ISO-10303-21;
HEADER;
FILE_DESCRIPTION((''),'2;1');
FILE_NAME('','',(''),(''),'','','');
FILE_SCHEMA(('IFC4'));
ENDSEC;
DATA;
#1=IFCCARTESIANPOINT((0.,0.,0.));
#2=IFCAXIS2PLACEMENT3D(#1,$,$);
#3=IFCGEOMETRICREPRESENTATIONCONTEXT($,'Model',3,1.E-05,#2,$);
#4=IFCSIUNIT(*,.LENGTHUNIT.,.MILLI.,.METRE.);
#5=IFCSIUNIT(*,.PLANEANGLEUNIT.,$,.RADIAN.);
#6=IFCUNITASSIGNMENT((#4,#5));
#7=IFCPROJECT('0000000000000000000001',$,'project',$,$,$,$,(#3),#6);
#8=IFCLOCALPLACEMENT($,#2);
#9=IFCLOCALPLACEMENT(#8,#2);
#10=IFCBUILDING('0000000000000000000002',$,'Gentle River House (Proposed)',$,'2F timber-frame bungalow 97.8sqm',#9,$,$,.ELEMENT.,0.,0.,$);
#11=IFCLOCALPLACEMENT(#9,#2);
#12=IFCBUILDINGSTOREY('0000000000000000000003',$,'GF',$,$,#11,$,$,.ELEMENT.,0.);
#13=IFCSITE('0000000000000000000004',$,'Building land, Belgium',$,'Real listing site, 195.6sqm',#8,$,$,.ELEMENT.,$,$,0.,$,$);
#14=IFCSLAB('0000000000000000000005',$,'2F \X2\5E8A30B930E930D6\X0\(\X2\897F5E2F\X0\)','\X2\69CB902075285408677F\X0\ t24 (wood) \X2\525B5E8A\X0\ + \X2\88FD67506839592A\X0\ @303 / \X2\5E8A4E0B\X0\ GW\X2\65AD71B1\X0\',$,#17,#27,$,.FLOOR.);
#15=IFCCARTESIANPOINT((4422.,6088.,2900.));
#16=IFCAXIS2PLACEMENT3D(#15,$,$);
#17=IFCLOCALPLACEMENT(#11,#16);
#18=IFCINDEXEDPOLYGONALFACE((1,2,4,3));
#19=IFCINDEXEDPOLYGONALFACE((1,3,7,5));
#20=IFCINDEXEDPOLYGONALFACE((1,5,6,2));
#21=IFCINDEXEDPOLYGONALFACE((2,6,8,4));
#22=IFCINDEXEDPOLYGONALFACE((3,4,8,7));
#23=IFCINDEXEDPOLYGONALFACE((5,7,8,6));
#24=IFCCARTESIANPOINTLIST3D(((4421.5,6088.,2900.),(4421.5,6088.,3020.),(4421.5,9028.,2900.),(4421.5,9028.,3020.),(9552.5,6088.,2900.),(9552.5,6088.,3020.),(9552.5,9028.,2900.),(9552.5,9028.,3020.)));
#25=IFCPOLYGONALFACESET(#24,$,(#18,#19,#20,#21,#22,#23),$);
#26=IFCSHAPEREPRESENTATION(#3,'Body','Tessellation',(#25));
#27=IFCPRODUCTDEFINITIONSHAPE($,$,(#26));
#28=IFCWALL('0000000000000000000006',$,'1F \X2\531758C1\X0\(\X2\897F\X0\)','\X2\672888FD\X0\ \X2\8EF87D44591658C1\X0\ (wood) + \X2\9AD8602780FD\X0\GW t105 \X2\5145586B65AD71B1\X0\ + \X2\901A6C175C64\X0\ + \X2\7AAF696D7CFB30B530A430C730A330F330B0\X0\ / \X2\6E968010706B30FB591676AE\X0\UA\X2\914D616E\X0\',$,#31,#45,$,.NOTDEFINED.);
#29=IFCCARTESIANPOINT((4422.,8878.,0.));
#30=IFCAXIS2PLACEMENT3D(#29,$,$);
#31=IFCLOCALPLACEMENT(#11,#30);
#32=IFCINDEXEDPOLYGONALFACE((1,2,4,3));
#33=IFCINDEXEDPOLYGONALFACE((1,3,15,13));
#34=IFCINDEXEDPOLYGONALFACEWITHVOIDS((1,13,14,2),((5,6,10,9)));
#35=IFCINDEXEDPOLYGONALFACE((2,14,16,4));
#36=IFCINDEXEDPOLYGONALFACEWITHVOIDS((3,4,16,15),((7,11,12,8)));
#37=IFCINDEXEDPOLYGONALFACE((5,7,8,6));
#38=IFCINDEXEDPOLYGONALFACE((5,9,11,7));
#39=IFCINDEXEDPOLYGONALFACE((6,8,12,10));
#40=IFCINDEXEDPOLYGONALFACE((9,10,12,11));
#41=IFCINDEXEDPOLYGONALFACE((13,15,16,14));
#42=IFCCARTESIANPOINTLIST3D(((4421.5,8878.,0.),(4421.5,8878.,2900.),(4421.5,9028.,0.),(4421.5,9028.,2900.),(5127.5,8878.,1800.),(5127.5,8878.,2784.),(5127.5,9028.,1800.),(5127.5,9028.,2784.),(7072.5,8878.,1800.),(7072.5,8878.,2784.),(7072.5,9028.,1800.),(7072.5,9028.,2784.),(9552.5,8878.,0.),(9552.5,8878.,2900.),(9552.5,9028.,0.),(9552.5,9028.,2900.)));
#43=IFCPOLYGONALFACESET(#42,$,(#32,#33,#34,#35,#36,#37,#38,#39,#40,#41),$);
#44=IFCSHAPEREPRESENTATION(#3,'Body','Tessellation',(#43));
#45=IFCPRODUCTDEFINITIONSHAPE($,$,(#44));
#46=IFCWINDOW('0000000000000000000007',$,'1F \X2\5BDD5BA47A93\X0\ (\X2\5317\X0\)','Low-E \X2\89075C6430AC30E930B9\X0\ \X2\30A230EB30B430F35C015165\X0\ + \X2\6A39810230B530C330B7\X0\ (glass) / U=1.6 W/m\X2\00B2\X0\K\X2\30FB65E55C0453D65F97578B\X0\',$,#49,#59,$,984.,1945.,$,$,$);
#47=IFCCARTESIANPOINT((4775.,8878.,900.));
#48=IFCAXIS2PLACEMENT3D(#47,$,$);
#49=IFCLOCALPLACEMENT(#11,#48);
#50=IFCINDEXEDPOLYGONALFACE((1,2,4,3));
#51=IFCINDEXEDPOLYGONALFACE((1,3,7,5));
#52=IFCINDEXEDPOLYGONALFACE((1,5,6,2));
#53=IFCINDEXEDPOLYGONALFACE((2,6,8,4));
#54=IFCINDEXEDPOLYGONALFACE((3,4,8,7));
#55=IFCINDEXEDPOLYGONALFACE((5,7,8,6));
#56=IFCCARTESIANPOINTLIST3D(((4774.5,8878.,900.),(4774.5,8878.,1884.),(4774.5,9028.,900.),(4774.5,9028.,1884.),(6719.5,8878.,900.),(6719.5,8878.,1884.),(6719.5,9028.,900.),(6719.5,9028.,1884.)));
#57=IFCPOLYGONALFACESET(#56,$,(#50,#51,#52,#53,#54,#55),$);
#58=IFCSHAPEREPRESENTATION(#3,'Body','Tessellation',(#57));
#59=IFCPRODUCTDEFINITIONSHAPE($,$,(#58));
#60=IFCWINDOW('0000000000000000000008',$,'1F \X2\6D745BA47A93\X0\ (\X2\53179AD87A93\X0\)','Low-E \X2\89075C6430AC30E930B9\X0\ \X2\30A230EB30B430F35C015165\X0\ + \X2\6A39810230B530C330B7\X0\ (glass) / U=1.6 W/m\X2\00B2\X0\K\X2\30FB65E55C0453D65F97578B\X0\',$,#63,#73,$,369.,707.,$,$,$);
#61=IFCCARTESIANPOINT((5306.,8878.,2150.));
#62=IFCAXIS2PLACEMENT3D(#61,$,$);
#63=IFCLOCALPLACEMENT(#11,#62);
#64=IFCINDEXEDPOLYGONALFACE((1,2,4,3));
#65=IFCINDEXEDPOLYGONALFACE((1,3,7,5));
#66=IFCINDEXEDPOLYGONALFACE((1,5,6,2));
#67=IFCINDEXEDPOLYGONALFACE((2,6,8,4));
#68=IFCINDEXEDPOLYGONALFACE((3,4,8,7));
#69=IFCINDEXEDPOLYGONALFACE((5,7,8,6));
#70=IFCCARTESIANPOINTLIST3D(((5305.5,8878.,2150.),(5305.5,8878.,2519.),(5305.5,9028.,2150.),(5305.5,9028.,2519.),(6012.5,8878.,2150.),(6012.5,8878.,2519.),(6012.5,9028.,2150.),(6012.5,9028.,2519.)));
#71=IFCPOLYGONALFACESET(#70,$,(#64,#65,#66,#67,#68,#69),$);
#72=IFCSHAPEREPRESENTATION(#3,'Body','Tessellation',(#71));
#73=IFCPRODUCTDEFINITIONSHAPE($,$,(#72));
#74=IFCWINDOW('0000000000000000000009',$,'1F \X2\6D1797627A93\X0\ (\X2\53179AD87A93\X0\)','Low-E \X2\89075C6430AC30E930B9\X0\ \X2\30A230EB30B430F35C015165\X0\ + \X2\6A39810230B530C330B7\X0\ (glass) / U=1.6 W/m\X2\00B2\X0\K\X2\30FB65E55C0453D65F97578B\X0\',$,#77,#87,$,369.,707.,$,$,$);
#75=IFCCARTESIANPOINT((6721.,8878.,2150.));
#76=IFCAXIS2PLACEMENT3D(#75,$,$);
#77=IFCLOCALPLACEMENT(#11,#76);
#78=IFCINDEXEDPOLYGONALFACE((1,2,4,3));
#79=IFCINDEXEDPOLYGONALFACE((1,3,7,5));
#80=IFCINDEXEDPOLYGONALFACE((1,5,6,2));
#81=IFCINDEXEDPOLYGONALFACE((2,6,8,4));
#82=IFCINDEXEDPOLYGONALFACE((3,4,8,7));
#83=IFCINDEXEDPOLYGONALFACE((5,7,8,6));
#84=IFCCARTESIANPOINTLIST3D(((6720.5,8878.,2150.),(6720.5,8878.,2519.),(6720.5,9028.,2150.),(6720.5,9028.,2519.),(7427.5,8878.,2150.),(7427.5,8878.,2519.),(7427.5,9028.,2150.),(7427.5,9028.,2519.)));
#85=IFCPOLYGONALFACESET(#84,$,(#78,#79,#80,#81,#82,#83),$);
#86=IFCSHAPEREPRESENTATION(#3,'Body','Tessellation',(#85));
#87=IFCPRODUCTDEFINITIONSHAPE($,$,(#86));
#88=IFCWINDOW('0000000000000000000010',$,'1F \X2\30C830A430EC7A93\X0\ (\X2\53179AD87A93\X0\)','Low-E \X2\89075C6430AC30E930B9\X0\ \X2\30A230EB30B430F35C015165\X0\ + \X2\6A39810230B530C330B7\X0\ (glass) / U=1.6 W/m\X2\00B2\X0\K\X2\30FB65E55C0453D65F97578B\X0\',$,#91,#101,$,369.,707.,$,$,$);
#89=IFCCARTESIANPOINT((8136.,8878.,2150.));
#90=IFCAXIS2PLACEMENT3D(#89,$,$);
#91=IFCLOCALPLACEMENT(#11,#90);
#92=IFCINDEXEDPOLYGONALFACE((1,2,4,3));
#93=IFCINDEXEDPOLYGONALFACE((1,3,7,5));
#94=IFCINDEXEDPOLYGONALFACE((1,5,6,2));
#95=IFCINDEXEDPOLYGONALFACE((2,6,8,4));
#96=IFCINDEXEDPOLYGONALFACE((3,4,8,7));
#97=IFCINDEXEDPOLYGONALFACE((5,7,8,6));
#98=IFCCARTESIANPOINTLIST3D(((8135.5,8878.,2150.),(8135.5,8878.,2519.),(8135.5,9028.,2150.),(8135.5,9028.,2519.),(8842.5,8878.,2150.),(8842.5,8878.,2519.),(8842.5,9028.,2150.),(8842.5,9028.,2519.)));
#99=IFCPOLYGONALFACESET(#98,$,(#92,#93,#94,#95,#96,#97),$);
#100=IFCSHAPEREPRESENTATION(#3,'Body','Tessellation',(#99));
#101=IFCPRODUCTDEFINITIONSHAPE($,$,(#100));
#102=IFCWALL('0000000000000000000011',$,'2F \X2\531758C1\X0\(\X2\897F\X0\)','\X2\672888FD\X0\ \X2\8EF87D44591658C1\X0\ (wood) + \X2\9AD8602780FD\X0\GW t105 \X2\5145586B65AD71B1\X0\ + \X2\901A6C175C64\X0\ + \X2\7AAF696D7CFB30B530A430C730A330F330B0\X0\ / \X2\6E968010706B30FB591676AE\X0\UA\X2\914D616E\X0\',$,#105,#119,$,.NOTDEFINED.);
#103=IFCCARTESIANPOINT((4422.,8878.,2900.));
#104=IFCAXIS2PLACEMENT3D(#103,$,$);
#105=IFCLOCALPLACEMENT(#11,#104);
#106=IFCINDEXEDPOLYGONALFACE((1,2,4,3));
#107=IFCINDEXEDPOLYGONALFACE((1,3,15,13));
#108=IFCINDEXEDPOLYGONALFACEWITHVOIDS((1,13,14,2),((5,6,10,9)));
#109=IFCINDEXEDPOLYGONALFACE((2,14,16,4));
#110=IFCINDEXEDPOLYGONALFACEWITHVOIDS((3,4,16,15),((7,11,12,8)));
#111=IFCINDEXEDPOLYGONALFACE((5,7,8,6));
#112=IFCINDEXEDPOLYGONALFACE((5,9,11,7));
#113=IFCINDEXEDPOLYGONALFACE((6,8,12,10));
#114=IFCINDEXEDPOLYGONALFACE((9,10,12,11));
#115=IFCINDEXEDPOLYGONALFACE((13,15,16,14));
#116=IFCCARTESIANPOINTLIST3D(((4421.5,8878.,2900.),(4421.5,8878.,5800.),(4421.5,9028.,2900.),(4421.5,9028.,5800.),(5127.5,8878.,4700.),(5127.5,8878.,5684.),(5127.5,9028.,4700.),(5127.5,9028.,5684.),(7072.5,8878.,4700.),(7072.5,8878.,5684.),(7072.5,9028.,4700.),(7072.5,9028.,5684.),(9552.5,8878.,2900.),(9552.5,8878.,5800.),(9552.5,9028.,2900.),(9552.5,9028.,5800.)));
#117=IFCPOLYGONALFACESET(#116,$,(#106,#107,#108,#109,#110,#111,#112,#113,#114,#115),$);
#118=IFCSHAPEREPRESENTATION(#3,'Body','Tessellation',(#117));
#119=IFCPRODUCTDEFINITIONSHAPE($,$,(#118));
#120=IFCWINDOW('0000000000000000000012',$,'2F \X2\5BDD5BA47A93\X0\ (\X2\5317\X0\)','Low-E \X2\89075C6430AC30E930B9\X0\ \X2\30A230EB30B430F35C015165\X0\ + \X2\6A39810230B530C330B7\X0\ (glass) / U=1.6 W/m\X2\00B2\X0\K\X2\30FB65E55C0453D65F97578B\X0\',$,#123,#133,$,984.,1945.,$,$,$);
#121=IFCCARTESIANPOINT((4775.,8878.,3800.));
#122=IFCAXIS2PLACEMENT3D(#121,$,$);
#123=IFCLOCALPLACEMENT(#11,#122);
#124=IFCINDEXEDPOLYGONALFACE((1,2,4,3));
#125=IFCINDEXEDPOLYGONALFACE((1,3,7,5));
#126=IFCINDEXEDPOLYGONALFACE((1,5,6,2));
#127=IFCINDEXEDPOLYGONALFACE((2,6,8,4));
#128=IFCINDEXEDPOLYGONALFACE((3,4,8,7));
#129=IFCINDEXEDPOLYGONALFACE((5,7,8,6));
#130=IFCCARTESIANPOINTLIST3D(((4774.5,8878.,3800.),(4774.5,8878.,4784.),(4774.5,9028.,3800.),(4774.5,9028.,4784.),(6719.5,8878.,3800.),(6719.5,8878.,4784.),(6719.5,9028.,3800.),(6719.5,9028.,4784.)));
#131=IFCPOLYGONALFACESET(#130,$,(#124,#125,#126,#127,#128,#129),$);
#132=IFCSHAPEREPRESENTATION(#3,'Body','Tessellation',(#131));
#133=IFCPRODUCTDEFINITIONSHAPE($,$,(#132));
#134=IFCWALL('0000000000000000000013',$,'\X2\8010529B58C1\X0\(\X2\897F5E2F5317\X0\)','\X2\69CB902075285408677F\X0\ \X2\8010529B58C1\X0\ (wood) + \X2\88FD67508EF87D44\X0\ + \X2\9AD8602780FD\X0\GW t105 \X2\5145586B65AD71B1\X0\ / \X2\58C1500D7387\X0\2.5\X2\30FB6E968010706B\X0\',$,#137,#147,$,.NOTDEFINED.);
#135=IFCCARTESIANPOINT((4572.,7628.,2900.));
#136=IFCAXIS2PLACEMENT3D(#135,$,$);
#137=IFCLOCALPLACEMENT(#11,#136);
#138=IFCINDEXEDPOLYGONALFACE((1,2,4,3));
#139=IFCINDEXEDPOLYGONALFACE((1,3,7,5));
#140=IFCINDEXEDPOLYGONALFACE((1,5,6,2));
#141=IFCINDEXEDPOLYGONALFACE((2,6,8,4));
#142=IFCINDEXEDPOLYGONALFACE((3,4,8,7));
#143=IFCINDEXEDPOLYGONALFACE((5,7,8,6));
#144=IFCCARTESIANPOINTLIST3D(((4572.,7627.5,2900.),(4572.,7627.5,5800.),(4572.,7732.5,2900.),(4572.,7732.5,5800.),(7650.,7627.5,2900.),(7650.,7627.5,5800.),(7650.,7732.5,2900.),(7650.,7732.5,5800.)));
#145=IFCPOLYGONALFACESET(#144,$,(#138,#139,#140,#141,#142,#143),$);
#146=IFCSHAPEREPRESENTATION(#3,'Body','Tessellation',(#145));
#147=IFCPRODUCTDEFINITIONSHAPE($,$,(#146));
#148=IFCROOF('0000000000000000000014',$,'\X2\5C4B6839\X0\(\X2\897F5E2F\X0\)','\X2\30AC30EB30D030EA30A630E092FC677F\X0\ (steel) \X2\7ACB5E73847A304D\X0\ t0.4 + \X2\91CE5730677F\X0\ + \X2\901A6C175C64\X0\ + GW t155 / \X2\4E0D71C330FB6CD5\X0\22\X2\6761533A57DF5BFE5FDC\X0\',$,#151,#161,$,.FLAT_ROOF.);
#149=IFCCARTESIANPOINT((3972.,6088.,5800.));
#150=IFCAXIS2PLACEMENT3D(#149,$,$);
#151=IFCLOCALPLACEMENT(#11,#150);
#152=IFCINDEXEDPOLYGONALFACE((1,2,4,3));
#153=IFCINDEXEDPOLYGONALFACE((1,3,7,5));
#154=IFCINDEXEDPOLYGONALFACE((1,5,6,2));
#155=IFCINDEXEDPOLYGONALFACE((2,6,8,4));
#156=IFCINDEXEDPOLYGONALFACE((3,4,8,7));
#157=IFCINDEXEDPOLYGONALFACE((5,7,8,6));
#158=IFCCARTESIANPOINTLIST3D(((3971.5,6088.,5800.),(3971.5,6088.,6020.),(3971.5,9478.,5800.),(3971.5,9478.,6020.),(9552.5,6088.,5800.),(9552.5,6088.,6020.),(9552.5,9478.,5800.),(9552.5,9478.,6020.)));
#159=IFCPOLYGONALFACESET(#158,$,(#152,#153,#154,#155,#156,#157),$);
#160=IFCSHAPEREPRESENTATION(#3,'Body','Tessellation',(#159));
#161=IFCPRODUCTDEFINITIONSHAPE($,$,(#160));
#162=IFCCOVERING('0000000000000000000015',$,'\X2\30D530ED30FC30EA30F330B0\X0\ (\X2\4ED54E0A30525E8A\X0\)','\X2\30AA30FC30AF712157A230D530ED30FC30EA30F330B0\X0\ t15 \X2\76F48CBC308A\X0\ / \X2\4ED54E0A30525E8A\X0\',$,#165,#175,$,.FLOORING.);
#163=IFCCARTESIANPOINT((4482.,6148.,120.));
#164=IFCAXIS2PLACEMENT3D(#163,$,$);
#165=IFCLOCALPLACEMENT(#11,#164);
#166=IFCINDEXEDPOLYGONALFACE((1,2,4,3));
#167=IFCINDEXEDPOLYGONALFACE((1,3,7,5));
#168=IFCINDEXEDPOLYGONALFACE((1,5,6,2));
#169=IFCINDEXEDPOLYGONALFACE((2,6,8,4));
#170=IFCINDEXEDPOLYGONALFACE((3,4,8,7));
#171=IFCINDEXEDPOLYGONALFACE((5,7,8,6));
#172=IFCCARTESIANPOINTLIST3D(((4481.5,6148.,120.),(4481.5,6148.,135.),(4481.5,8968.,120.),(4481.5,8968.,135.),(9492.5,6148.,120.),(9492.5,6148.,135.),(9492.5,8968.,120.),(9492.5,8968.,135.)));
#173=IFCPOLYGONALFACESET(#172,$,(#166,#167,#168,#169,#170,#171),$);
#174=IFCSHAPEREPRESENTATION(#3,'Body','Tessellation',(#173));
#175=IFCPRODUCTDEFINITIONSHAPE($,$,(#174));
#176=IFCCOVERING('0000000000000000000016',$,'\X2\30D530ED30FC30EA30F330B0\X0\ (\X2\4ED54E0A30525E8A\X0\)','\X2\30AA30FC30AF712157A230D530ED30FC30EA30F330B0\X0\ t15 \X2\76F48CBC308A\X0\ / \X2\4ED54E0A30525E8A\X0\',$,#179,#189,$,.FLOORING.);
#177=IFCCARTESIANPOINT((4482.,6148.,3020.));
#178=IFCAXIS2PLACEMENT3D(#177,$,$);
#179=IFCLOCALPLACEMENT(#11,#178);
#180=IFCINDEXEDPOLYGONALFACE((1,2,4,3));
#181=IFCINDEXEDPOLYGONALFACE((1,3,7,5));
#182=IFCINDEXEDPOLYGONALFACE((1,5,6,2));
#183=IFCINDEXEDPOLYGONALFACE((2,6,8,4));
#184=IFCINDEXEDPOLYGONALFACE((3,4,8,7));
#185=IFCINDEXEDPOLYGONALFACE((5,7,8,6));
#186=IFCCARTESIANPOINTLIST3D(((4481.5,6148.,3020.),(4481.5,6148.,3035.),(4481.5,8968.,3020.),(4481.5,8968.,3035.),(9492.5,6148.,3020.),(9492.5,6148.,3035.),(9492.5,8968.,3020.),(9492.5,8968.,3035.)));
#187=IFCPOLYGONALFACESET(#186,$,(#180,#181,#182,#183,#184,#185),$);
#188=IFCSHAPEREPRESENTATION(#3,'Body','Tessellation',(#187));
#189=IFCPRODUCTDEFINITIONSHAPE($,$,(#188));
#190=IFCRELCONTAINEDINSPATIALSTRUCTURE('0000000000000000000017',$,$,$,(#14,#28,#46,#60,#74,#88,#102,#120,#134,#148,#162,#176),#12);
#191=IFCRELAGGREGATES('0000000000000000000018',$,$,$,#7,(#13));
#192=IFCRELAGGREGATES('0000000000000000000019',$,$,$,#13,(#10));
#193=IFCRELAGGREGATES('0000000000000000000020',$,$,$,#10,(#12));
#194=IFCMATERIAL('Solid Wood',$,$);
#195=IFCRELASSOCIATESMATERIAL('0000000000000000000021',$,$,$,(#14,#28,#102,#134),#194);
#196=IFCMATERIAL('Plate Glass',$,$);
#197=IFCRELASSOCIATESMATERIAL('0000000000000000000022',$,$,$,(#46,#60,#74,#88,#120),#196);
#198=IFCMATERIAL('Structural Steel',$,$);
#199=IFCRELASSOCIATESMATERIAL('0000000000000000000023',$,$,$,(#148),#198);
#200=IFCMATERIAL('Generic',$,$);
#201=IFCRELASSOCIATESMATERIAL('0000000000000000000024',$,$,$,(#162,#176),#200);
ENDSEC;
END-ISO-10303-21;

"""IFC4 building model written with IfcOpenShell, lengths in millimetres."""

from ifc_helpers import new_model, si_unit, frame, frame_2d, origin, place, context, project, spatial, rectangle, extrude, material, element, fill, save


model = new_model("IFC4")

# Units and contexts
model_context = context("Model", 3, precision=1e-05, world=origin())
ifc_project = project(units=[si_unit("LENGTHUNIT", "METRE", prefix="MILLI"), si_unit("PLANEANGLEUNIT", "RADIAN")], contexts=[model_context])

# Site, building, storey
site_placement = place(None, origin())
site = spatial("IfcSite", under=ifc_project, at=site_placement, Name="Building land, Belgium", ObjectType="Real listing site, 195.6sqm", CompositionType="ELEMENT", RefElevation=0.0)
building_placement = place(site_placement, origin())
building = spatial("IfcBuilding", under=site, at=building_placement, Name="Gentle River House (Proposed)", ObjectType="2F timber-frame bungalow 97.8sqm", CompositionType="ELEMENT", ElevationOfRefHeight=0.0, ElevationOfTerrain=0.0)
storey_placement = place(building_placement, origin())
storey = spatial("IfcBuildingStorey", under=building, at=storey_placement, Name="GF", CompositionType="ELEMENT", Elevation=0.0)

# Slab
ifc_material_1 = material(Name="Solid Wood")
slab_1_placement = place(storey_placement, frame((4422.0, 6088.0, 2900.0)))
element("IfcSlab", 1, at=slab_1_placement, inside=storey, material=ifc_material_1, Name="2F 床スラブ(西帯)", Description="構造用合板 t24 (wood) 剛床 + 製材根太 @303 / 床下 GW断熱", PredefinedType="FLOOR", context=model_context, shape_type="SweptSolid", body=[
    extrude(rectangle(XDim=5131.0, YDim=2940.0, at=frame_2d((2565.0, 1470.0))), frame((4422.0, 6088.0, 2900.0)), (0.0, 0.0, 1.0), 120.0),
])

# Wall, openings, windows
wall_1_placement = place(storey_placement, frame((4422.0, 8878.0, 0.0)))
wall_1 = element("IfcWall", 2, at=wall_1_placement, inside=storey, material=ifc_material_1, Name="1F 北壁(西)", Description="木製 軸組外壁 (wood) + 高性能GW t105 充填断熱 + 通気層 + 窯業系サイディング / 準耐火・外皮UA配慮", PredefinedType="NOTDEFINED", context=model_context, shape_type="SweptSolid", body=[
    extrude(rectangle(XDim=5131.0, YDim=150.0, at=frame_2d((2565.0, 75.0))), frame((4422.0, 8878.0, 0.0)), (0.0, 0.0, 1.0), 2900.0),
])
opening_1_placement = place(storey_placement, frame((4775.0, 8878.0, 900.0)))
opening_1 = element("IfcOpeningElement", 3, at=opening_1_placement, cuts=wall_1, PredefinedType="NOTDEFINED", context=model_context, shape_type="SweptSolid", body=[
    extrude(rectangle(XDim=1945.0, YDim=150.0, at=frame_2d((972.0, 75.0))), frame((4775.0, 8878.0, 900.0)), (0.0, 0.0, 1.0), 984.0),
])
opening_2_placement = place(storey_placement, frame((5306.0, 8878.0, 2150.0)))
opening_2 = element("IfcOpeningElement", 4, at=opening_2_placement, cuts=wall_1, PredefinedType="NOTDEFINED", context=model_context, shape_type="SweptSolid", body=[
    extrude(rectangle(XDim=707.0, YDim=150.0, at=frame_2d((353.0, 75.0))), frame((5306.0, 8878.0, 2150.0)), (0.0, 0.0, 1.0), 369.0),
])
opening_3_placement = place(storey_placement, frame((6721.0, 8878.0, 2150.0)))
opening_3 = element("IfcOpeningElement", 5, at=opening_3_placement, cuts=wall_1, PredefinedType="NOTDEFINED", context=model_context, shape_type="SweptSolid", body=[
    extrude(rectangle(XDim=707.0, YDim=150.0, at=frame_2d((353.0, 75.0))), frame((6721.0, 8878.0, 2150.0)), (0.0, 0.0, 1.0), 369.0),
])
opening_4_placement = place(storey_placement, frame((8136.0, 8878.0, 2150.0)))
opening_4 = element("IfcOpeningElement", 6, at=opening_4_placement, cuts=wall_1, PredefinedType="NOTDEFINED", context=model_context, shape_type="SweptSolid", body=[
    extrude(rectangle(XDim=707.0, YDim=150.0, at=frame_2d((353.0, 75.0))), frame((8136.0, 8878.0, 2150.0)), (0.0, 0.0, 1.0), 369.0),
])
ifc_material_2 = material(Name="Plate Glass")
window_1_placement = place(storey_placement, frame((4775.0, 8878.0, 900.0)))
window_1 = element("IfcWindow", 7, at=window_1_placement, inside=storey, material=ifc_material_2, Name="1F 寝室窓 (北)", Description="Low-E 複層ガラス アルゴン封入 + 樹脂サッシ (glass) / U=1.6 W/m²K・日射取得型", OverallHeight=984.0, OverallWidth=1945.0, context=model_context, shape_type="SweptSolid", body=[
    extrude(rectangle(XDim=1945.0, YDim=150.0, at=frame_2d((972.0, 75.0))), frame((4775.0, 8878.0, 900.0)), (0.0, 0.0, 1.0), 984.0),
])
fill(opening_1, window_1)
window_2_placement = place(storey_placement, frame((5306.0, 8878.0, 2150.0)))
window_2 = element("IfcWindow", 8, at=window_2_placement, inside=storey, material=ifc_material_2, Name="1F 浴室窓 (北高窓)", Description="Low-E 複層ガラス アルゴン封入 + 樹脂サッシ (glass) / U=1.6 W/m²K・日射取得型", OverallHeight=369.0, OverallWidth=707.0, context=model_context, shape_type="SweptSolid", body=[
    extrude(rectangle(XDim=707.0, YDim=150.0, at=frame_2d((353.0, 75.0))), frame((5306.0, 8878.0, 2150.0)), (0.0, 0.0, 1.0), 369.0),
])
fill(opening_2, window_2)
window_3_placement = place(storey_placement, frame((6721.0, 8878.0, 2150.0)))
window_3 = element("IfcWindow", 9, at=window_3_placement, inside=storey, material=ifc_material_2, Name="1F 洗面窓 (北高窓)", Description="Low-E 複層ガラス アルゴン封入 + 樹脂サッシ (glass) / U=1.6 W/m²K・日射取得型", OverallHeight=369.0, OverallWidth=707.0, context=model_context, shape_type="SweptSolid", body=[
    extrude(rectangle(XDim=707.0, YDim=150.0, at=frame_2d((353.0, 75.0))), frame((6721.0, 8878.0, 2150.0)), (0.0, 0.0, 1.0), 369.0),
])
fill(opening_3, window_3)
window_4_placement = place(storey_placement, frame((8136.0, 8878.0, 2150.0)))
window_4 = element("IfcWindow", 10, at=window_4_placement, inside=storey, material=ifc_material_2, Name="1F トイレ窓 (北高窓)", Description="Low-E 複層ガラス アルゴン封入 + 樹脂サッシ (glass) / U=1.6 W/m²K・日射取得型", OverallHeight=369.0, OverallWidth=707.0, context=model_context, shape_type="SweptSolid", body=[
    extrude(rectangle(XDim=707.0, YDim=150.0, at=frame_2d((353.0, 75.0))), frame((8136.0, 8878.0, 2150.0)), (0.0, 0.0, 1.0), 369.0),
])
fill(opening_4, window_4)

# Wall, opening, window
wall_2_placement = place(storey_placement, frame((4422.0, 8878.0, 2900.0)))
wall_2 = element("IfcWall", 11, at=wall_2_placement, inside=storey, material=ifc_material_1, Name="2F 北壁(西)", Description="木製 軸組外壁 (wood) + 高性能GW t105 充填断熱 + 通気層 + 窯業系サイディング / 準耐火・外皮UA配慮", PredefinedType="NOTDEFINED", context=model_context, shape_type="SweptSolid", body=[
    extrude(rectangle(XDim=5131.0, YDim=150.0, at=frame_2d((2565.0, 75.0))), frame((4422.0, 8878.0, 2900.0)), (0.0, 0.0, 1.0), 2900.0),
])
opening_5_placement = place(storey_placement, frame((4775.0, 8878.0, 3800.0)))
opening_5 = element("IfcOpeningElement", 12, at=opening_5_placement, cuts=wall_2, PredefinedType="NOTDEFINED", context=model_context, shape_type="SweptSolid", body=[
    extrude(rectangle(XDim=1945.0, YDim=150.0, at=frame_2d((972.0, 75.0))), frame((4775.0, 8878.0, 3800.0)), (0.0, 0.0, 1.0), 984.0),
])
window_5_placement = place(storey_placement, frame((4775.0, 8878.0, 3800.0)))
window_5 = element("IfcWindow", 13, at=window_5_placement, inside=storey, material=ifc_material_2, Name="2F 寝室窓 (北)", Description="Low-E 複層ガラス アルゴン封入 + 樹脂サッシ (glass) / U=1.6 W/m²K・日射取得型", OverallHeight=984.0, OverallWidth=1945.0, context=model_context, shape_type="SweptSolid", body=[
    extrude(rectangle(XDim=1945.0, YDim=150.0, at=frame_2d((972.0, 75.0))), frame((4775.0, 8878.0, 3800.0)), (0.0, 0.0, 1.0), 984.0),
])
fill(opening_5, window_5)

# Wall
wall_3_placement = place(storey_placement, frame((4572.0, 7628.0, 2900.0)))
element("IfcWall", 14, at=wall_3_placement, inside=storey, material=ifc_material_1, Name="耐力壁(西帯北)", Description="構造用合板 耐力壁 (wood) + 製材軸組 + 高性能GW t105 充填断熱 / 壁倍率2.5・準耐火", PredefinedType="NOTDEFINED", context=model_context, shape_type="SweptSolid", body=[
    extrude(rectangle(XDim=3078.0, YDim=105.0, at=frame_2d((1539.0, 52.0))), frame((4572.0, 7628.0, 2900.0)), (0.0, 0.0, 1.0), 2900.0),
])

# Roof
ifc_material_3 = material(Name="Structural Steel")
for number, where, name in (
    (15, (3972.0, 6088.0, 5800.0), "屋根(西帯)"),
):
    element("IfcRoof", number, at=place(storey_placement, frame(where)), inside=storey, material=ifc_material_3, Name=name, Description="ガルバリウム鋼板 (steel) 立平葺き t0.4 + 野地板 + 通気層 + GW t155 / 不燃・法22条区域対応", PredefinedType="FLAT_ROOF", context=model_context, shape_type="SweptSolid", body=[
        extrude(rectangle(XDim=5581.0, YDim=3390.0, at=frame_2d((2790.0, 1695.0))), frame((3972.0, 6088.0, 5800.0)), (0.0, 0.0, 1.0), 220.0),
    ])

# Coverings
ifc_material_4 = material(Name="Generic")
covering_1_placement = place(storey_placement, frame((4482.0, 6148.0, 120.0)))
element("IfcCovering", 16, at=covering_1_placement, inside=storey, material=ifc_material_4, Name="フローリング (仕上げ床)", Description="オーク無垢フローリング t15 直貼り / 仕上げ床", PredefinedType="FLOORING", context=model_context, shape_type="SweptSolid", body=[
    extrude(rectangle(XDim=5011.0, YDim=2820.0, at=frame_2d((2505.0, 1410.0))), frame((4482.0, 6148.0, 120.0)), (0.0, 0.0, 1.0), 15.0),
])
covering_2_placement = place(storey_placement, frame((4482.0, 6148.0, 3020.0)))
element("IfcCovering", 17, at=covering_2_placement, inside=storey, material=ifc_material_4, Name="フローリング (仕上げ床)", Description="オーク無垢フローリング t15 直貼り / 仕上げ床", PredefinedType="FLOORING", context=model_context, shape_type="SweptSolid", body=[
    extrude(rectangle(XDim=5011.0, YDim=2820.0, at=frame_2d((2505.0, 1410.0))), frame((4482.0, 6148.0, 3020.0)), (0.0, 0.0, 1.0), 15.0),
])

save(model, "model.ifc")
